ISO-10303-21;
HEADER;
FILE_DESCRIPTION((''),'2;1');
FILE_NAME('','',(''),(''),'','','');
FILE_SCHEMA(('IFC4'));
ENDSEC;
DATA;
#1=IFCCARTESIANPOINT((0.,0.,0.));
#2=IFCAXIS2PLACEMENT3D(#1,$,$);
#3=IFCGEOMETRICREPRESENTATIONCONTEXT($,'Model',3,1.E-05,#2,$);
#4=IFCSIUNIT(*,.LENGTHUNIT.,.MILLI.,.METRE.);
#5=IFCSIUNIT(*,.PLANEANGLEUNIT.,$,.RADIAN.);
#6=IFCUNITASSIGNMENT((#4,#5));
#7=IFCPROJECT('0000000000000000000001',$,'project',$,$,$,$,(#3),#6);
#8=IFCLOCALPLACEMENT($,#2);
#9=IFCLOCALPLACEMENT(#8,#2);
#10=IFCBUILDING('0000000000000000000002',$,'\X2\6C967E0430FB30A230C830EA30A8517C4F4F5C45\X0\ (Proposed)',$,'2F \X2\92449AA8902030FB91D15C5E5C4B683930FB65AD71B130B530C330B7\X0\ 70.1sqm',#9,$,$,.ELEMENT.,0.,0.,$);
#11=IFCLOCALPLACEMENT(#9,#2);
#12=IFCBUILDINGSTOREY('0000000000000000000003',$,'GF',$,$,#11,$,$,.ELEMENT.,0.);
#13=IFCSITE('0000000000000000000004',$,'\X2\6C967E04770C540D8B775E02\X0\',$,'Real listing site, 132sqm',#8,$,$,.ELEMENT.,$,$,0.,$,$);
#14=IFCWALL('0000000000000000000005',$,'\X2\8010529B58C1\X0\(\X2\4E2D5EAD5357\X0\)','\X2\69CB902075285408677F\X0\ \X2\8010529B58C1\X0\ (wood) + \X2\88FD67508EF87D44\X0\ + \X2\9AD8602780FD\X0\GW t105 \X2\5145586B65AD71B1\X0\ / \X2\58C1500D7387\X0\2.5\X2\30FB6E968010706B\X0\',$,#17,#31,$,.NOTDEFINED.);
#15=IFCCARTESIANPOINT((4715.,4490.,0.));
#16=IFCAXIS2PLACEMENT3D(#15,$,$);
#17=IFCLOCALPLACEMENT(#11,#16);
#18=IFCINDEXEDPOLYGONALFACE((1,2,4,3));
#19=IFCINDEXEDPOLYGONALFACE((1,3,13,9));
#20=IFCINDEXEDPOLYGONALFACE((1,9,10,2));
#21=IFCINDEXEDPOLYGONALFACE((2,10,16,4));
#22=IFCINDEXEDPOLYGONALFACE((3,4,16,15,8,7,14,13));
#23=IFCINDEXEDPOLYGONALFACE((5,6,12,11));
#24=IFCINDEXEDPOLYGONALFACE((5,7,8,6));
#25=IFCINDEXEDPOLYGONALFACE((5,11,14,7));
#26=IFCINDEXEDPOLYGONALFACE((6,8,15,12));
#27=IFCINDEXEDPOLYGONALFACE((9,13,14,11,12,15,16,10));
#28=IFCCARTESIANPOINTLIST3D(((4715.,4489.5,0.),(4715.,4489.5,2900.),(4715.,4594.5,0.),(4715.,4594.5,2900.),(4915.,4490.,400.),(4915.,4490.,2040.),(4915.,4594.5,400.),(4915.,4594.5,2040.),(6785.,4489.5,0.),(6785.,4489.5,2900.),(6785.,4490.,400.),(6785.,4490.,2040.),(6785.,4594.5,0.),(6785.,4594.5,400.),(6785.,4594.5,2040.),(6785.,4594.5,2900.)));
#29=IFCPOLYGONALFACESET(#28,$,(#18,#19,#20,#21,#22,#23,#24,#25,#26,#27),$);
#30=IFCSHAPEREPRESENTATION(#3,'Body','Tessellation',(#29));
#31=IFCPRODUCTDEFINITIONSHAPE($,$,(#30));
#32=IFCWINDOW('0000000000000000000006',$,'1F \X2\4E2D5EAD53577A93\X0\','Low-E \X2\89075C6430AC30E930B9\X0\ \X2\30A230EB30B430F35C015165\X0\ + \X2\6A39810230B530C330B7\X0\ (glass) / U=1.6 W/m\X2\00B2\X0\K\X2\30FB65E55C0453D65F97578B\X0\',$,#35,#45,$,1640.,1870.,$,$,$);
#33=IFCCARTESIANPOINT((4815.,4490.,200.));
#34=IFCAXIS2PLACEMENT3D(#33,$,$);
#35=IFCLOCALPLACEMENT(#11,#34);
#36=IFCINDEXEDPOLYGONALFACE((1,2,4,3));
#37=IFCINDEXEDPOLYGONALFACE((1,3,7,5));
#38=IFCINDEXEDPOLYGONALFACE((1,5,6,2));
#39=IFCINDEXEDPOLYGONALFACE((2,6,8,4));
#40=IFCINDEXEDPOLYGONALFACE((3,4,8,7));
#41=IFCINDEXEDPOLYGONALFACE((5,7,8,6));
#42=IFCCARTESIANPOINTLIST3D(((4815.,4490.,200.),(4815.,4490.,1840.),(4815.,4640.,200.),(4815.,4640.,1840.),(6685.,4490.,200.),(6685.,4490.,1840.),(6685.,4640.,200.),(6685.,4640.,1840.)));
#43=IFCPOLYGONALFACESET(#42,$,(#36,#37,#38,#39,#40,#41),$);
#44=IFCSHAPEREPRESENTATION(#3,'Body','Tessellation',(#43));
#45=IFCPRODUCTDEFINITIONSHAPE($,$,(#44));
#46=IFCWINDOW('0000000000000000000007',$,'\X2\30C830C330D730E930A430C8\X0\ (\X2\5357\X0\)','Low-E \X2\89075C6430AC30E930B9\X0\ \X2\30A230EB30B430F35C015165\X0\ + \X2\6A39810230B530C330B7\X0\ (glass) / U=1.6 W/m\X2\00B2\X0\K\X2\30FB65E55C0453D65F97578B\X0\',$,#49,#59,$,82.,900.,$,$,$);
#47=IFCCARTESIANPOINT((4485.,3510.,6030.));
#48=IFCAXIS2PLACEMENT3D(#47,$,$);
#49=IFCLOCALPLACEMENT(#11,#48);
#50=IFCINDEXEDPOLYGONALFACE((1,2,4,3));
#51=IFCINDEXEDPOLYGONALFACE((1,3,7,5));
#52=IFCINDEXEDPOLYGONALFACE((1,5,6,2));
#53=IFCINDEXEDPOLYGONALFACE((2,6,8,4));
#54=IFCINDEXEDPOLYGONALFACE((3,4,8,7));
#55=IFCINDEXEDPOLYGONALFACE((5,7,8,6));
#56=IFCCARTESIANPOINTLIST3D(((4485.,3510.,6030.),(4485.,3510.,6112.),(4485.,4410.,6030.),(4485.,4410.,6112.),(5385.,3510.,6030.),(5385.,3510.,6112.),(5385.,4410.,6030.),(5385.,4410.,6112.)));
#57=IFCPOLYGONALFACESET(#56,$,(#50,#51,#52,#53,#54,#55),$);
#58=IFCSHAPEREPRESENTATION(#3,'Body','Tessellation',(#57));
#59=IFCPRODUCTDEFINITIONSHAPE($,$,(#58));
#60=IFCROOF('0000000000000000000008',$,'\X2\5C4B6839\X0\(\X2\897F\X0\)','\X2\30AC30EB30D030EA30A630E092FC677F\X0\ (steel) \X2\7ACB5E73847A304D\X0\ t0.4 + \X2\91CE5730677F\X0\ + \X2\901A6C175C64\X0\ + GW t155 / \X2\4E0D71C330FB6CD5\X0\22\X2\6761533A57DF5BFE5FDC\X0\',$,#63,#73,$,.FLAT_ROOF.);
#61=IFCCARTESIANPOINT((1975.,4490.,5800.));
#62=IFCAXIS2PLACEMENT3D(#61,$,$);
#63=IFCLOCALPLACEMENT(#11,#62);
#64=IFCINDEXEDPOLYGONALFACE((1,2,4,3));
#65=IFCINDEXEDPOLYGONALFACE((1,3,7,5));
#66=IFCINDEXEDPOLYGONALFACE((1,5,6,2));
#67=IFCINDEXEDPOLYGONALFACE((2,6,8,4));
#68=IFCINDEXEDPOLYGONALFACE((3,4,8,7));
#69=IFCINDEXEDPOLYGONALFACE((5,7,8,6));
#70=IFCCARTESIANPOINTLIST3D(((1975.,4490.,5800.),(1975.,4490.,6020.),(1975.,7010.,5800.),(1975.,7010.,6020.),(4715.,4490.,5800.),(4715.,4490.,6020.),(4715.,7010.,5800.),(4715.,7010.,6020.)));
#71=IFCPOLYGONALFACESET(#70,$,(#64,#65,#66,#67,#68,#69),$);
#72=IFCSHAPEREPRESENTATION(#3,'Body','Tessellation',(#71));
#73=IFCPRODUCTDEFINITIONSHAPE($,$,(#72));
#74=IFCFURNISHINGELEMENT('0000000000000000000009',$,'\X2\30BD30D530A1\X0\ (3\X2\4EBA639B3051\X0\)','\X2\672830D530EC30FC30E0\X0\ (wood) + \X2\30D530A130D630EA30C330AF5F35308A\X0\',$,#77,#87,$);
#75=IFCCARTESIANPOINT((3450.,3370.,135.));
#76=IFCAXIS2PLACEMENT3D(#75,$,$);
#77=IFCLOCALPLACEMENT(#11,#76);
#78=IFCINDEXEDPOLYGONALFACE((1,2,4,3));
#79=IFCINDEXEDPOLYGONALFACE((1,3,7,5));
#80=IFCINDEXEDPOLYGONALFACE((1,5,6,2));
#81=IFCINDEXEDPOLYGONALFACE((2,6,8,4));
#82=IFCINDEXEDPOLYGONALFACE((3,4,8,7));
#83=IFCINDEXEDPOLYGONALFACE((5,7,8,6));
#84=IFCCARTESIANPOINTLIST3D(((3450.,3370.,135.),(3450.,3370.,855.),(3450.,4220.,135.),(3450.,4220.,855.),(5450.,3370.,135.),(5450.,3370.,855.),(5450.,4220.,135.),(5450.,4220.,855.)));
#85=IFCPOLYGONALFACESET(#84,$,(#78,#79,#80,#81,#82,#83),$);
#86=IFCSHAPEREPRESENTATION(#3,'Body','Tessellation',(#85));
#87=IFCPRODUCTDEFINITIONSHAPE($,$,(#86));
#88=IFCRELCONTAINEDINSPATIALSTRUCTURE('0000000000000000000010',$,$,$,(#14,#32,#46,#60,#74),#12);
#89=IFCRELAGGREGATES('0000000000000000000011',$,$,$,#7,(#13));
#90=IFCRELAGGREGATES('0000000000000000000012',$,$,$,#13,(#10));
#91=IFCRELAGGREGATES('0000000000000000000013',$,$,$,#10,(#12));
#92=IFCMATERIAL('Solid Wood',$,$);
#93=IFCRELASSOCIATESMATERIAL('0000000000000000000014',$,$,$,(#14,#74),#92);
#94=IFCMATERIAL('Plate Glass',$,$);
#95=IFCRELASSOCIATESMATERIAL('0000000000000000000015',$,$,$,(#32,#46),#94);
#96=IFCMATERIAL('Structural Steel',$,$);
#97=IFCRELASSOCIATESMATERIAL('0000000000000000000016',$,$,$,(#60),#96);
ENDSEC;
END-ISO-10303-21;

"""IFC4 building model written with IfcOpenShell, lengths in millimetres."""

from ifc_helpers import new_model, si_unit, frame, frame_2d, origin, place, context, project, spatial, rectangle, extrude, material, element, fill, save


model = new_model("IFC4")

# Units and contexts
model_context = context("Model", 3, precision=1e-05, world=origin())
ifc_project = project(units=[si_unit("LENGTHUNIT", "METRE", prefix="MILLI"), si_unit("PLANEANGLEUNIT", "RADIAN")], contexts=[model_context])

# Site, building, storey
site_placement = place(None, origin())
site = spatial("IfcSite", under=ifc_project, at=site_placement, Name="沖縄県名護市", ObjectType="Real listing site, 132sqm", CompositionType="ELEMENT", RefElevation=0.0)
building_placement = place(site_placement, origin())
building = spatial("IfcBuilding", under=site, at=building_placement, Name="沖縄・アトリエ兼住居 (Proposed)", ObjectType="2F 鉄骨造・金属屋根・断熱サッシ 70.1sqm", CompositionType="ELEMENT", ElevationOfRefHeight=0.0, ElevationOfTerrain=0.0)
storey_placement = place(building_placement, origin())
storey = spatial("IfcBuildingStorey", under=building, at=storey_placement, Name="GF", CompositionType="ELEMENT", Elevation=0.0)

# Shared definitions
ifc_material_1 = material(Name="Solid Wood")

# Wall, opening, window
wall_placement = place(storey_placement, frame((4715.0, 4490.0, 0.0)))
wall = element("IfcWall", 1, at=wall_placement, inside=storey, material=ifc_material_1, Name="耐力壁(中庭南)", Description="構造用合板 耐力壁 (wood) + 製材軸組 + 高性能GW t105 充填断熱 / 壁倍率2.5・準耐火", PredefinedType="NOTDEFINED", context=model_context, shape_type="SweptSolid", body=[
    extrude(rectangle(XDim=2070.0, YDim=105.0, at=frame_2d((1035.0, 52.0))), frame((4715.0, 4490.0, 0.0)), (0.0, 0.0, 1.0), 2900.0),
])
opening_placement = place(storey_placement, frame((4815.0, 4490.0, 200.0)))
opening = element("IfcOpeningElement", 2, at=opening_placement, cuts=wall, PredefinedType="NOTDEFINED", context=model_context, shape_type="SweptSolid", body=[
    extrude(rectangle(XDim=1870.0, YDim=150.0, at=frame_2d((935.0, 75.0))), frame((4815.0, 4490.0, 200.0)), (0.0, 0.0, 1.0), 1640.0),
])
ifc_material_2 = material(Name="Plate Glass")
window_1_placement = place(storey_placement, frame((4815.0, 4490.0, 200.0)))
window_1 = element("IfcWindow", 3, at=window_1_placement, inside=storey, material=ifc_material_2, Name="1F 中庭南窓", Description="Low-E 複層ガラス アルゴン封入 + 樹脂サッシ (glass) / U=1.6 W/m²K・日射取得型", OverallHeight=1640.0, OverallWidth=1870.0, context=model_context, shape_type="SweptSolid", body=[
    extrude(rectangle(XDim=1870.0, YDim=150.0, at=frame_2d((935.0, 75.0))), frame((4815.0, 4490.0, 200.0)), (0.0, 0.0, 1.0), 1640.0),
])
fill(opening, window_1)

# Window
window_2_placement = place(storey_placement, frame((4485.0, 3510.0, 6030.0)))
element("IfcWindow", 4, at=window_2_placement, inside=storey, material=ifc_material_2, Name="トップライト (南)", Description="Low-E 複層ガラス アルゴン封入 + 樹脂サッシ (glass) / U=1.6 W/m²K・日射取得型", OverallHeight=82.0, OverallWidth=900.0, context=model_context, shape_type="SweptSolid", body=[
    extrude(rectangle(XDim=900.0, YDim=900.0, at=frame_2d((450.0, 450.0))), frame((4485.0, 3510.0, 6030.0)), (0.0, 0.0, 1.0), 82.0),
])

# Roof
ifc_material_3 = material(Name="Structural Steel")
for number, where, name in (
    (5, (1975.0, 4490.0, 5800.0), "屋根(西)"),
):
    element("IfcRoof", number, at=place(storey_placement, frame(where)), inside=storey, material=ifc_material_3, Name=name, Description="ガルバリウム鋼板 (steel) 立平葺き t0.4 + 野地板 + 通気層 + GW t155 / 不燃・法22条区域対応", PredefinedType="FLAT_ROOF", context=model_context, shape_type="SweptSolid", body=[
        extrude(rectangle(XDim=2740.0, YDim=2520.0, at=frame_2d((1370.0, 1260.0))), frame((1975.0, 4490.0, 5800.0)), (0.0, 0.0, 1.0), 220.0),
    ])

# Furnishing element
furnishing_placement = place(storey_placement, frame((3450.0, 3370.0, 135.0)))
element("IfcFurnishingElement", 6, at=furnishing_placement, inside=storey, material=ifc_material_1, Name="ソファ (3人掛け)", Description="木フレーム (wood) + ファブリック張り", context=model_context, shape_type="SweptSolid", body=[
    extrude(rectangle(XDim=2000.0, YDim=850.0, at=frame_2d((1000.0, 425.0))), frame((3450.0, 3370.0, 135.0)), (0.0, 0.0, 1.0), 720.0),
])

save(model, "model.ifc")
